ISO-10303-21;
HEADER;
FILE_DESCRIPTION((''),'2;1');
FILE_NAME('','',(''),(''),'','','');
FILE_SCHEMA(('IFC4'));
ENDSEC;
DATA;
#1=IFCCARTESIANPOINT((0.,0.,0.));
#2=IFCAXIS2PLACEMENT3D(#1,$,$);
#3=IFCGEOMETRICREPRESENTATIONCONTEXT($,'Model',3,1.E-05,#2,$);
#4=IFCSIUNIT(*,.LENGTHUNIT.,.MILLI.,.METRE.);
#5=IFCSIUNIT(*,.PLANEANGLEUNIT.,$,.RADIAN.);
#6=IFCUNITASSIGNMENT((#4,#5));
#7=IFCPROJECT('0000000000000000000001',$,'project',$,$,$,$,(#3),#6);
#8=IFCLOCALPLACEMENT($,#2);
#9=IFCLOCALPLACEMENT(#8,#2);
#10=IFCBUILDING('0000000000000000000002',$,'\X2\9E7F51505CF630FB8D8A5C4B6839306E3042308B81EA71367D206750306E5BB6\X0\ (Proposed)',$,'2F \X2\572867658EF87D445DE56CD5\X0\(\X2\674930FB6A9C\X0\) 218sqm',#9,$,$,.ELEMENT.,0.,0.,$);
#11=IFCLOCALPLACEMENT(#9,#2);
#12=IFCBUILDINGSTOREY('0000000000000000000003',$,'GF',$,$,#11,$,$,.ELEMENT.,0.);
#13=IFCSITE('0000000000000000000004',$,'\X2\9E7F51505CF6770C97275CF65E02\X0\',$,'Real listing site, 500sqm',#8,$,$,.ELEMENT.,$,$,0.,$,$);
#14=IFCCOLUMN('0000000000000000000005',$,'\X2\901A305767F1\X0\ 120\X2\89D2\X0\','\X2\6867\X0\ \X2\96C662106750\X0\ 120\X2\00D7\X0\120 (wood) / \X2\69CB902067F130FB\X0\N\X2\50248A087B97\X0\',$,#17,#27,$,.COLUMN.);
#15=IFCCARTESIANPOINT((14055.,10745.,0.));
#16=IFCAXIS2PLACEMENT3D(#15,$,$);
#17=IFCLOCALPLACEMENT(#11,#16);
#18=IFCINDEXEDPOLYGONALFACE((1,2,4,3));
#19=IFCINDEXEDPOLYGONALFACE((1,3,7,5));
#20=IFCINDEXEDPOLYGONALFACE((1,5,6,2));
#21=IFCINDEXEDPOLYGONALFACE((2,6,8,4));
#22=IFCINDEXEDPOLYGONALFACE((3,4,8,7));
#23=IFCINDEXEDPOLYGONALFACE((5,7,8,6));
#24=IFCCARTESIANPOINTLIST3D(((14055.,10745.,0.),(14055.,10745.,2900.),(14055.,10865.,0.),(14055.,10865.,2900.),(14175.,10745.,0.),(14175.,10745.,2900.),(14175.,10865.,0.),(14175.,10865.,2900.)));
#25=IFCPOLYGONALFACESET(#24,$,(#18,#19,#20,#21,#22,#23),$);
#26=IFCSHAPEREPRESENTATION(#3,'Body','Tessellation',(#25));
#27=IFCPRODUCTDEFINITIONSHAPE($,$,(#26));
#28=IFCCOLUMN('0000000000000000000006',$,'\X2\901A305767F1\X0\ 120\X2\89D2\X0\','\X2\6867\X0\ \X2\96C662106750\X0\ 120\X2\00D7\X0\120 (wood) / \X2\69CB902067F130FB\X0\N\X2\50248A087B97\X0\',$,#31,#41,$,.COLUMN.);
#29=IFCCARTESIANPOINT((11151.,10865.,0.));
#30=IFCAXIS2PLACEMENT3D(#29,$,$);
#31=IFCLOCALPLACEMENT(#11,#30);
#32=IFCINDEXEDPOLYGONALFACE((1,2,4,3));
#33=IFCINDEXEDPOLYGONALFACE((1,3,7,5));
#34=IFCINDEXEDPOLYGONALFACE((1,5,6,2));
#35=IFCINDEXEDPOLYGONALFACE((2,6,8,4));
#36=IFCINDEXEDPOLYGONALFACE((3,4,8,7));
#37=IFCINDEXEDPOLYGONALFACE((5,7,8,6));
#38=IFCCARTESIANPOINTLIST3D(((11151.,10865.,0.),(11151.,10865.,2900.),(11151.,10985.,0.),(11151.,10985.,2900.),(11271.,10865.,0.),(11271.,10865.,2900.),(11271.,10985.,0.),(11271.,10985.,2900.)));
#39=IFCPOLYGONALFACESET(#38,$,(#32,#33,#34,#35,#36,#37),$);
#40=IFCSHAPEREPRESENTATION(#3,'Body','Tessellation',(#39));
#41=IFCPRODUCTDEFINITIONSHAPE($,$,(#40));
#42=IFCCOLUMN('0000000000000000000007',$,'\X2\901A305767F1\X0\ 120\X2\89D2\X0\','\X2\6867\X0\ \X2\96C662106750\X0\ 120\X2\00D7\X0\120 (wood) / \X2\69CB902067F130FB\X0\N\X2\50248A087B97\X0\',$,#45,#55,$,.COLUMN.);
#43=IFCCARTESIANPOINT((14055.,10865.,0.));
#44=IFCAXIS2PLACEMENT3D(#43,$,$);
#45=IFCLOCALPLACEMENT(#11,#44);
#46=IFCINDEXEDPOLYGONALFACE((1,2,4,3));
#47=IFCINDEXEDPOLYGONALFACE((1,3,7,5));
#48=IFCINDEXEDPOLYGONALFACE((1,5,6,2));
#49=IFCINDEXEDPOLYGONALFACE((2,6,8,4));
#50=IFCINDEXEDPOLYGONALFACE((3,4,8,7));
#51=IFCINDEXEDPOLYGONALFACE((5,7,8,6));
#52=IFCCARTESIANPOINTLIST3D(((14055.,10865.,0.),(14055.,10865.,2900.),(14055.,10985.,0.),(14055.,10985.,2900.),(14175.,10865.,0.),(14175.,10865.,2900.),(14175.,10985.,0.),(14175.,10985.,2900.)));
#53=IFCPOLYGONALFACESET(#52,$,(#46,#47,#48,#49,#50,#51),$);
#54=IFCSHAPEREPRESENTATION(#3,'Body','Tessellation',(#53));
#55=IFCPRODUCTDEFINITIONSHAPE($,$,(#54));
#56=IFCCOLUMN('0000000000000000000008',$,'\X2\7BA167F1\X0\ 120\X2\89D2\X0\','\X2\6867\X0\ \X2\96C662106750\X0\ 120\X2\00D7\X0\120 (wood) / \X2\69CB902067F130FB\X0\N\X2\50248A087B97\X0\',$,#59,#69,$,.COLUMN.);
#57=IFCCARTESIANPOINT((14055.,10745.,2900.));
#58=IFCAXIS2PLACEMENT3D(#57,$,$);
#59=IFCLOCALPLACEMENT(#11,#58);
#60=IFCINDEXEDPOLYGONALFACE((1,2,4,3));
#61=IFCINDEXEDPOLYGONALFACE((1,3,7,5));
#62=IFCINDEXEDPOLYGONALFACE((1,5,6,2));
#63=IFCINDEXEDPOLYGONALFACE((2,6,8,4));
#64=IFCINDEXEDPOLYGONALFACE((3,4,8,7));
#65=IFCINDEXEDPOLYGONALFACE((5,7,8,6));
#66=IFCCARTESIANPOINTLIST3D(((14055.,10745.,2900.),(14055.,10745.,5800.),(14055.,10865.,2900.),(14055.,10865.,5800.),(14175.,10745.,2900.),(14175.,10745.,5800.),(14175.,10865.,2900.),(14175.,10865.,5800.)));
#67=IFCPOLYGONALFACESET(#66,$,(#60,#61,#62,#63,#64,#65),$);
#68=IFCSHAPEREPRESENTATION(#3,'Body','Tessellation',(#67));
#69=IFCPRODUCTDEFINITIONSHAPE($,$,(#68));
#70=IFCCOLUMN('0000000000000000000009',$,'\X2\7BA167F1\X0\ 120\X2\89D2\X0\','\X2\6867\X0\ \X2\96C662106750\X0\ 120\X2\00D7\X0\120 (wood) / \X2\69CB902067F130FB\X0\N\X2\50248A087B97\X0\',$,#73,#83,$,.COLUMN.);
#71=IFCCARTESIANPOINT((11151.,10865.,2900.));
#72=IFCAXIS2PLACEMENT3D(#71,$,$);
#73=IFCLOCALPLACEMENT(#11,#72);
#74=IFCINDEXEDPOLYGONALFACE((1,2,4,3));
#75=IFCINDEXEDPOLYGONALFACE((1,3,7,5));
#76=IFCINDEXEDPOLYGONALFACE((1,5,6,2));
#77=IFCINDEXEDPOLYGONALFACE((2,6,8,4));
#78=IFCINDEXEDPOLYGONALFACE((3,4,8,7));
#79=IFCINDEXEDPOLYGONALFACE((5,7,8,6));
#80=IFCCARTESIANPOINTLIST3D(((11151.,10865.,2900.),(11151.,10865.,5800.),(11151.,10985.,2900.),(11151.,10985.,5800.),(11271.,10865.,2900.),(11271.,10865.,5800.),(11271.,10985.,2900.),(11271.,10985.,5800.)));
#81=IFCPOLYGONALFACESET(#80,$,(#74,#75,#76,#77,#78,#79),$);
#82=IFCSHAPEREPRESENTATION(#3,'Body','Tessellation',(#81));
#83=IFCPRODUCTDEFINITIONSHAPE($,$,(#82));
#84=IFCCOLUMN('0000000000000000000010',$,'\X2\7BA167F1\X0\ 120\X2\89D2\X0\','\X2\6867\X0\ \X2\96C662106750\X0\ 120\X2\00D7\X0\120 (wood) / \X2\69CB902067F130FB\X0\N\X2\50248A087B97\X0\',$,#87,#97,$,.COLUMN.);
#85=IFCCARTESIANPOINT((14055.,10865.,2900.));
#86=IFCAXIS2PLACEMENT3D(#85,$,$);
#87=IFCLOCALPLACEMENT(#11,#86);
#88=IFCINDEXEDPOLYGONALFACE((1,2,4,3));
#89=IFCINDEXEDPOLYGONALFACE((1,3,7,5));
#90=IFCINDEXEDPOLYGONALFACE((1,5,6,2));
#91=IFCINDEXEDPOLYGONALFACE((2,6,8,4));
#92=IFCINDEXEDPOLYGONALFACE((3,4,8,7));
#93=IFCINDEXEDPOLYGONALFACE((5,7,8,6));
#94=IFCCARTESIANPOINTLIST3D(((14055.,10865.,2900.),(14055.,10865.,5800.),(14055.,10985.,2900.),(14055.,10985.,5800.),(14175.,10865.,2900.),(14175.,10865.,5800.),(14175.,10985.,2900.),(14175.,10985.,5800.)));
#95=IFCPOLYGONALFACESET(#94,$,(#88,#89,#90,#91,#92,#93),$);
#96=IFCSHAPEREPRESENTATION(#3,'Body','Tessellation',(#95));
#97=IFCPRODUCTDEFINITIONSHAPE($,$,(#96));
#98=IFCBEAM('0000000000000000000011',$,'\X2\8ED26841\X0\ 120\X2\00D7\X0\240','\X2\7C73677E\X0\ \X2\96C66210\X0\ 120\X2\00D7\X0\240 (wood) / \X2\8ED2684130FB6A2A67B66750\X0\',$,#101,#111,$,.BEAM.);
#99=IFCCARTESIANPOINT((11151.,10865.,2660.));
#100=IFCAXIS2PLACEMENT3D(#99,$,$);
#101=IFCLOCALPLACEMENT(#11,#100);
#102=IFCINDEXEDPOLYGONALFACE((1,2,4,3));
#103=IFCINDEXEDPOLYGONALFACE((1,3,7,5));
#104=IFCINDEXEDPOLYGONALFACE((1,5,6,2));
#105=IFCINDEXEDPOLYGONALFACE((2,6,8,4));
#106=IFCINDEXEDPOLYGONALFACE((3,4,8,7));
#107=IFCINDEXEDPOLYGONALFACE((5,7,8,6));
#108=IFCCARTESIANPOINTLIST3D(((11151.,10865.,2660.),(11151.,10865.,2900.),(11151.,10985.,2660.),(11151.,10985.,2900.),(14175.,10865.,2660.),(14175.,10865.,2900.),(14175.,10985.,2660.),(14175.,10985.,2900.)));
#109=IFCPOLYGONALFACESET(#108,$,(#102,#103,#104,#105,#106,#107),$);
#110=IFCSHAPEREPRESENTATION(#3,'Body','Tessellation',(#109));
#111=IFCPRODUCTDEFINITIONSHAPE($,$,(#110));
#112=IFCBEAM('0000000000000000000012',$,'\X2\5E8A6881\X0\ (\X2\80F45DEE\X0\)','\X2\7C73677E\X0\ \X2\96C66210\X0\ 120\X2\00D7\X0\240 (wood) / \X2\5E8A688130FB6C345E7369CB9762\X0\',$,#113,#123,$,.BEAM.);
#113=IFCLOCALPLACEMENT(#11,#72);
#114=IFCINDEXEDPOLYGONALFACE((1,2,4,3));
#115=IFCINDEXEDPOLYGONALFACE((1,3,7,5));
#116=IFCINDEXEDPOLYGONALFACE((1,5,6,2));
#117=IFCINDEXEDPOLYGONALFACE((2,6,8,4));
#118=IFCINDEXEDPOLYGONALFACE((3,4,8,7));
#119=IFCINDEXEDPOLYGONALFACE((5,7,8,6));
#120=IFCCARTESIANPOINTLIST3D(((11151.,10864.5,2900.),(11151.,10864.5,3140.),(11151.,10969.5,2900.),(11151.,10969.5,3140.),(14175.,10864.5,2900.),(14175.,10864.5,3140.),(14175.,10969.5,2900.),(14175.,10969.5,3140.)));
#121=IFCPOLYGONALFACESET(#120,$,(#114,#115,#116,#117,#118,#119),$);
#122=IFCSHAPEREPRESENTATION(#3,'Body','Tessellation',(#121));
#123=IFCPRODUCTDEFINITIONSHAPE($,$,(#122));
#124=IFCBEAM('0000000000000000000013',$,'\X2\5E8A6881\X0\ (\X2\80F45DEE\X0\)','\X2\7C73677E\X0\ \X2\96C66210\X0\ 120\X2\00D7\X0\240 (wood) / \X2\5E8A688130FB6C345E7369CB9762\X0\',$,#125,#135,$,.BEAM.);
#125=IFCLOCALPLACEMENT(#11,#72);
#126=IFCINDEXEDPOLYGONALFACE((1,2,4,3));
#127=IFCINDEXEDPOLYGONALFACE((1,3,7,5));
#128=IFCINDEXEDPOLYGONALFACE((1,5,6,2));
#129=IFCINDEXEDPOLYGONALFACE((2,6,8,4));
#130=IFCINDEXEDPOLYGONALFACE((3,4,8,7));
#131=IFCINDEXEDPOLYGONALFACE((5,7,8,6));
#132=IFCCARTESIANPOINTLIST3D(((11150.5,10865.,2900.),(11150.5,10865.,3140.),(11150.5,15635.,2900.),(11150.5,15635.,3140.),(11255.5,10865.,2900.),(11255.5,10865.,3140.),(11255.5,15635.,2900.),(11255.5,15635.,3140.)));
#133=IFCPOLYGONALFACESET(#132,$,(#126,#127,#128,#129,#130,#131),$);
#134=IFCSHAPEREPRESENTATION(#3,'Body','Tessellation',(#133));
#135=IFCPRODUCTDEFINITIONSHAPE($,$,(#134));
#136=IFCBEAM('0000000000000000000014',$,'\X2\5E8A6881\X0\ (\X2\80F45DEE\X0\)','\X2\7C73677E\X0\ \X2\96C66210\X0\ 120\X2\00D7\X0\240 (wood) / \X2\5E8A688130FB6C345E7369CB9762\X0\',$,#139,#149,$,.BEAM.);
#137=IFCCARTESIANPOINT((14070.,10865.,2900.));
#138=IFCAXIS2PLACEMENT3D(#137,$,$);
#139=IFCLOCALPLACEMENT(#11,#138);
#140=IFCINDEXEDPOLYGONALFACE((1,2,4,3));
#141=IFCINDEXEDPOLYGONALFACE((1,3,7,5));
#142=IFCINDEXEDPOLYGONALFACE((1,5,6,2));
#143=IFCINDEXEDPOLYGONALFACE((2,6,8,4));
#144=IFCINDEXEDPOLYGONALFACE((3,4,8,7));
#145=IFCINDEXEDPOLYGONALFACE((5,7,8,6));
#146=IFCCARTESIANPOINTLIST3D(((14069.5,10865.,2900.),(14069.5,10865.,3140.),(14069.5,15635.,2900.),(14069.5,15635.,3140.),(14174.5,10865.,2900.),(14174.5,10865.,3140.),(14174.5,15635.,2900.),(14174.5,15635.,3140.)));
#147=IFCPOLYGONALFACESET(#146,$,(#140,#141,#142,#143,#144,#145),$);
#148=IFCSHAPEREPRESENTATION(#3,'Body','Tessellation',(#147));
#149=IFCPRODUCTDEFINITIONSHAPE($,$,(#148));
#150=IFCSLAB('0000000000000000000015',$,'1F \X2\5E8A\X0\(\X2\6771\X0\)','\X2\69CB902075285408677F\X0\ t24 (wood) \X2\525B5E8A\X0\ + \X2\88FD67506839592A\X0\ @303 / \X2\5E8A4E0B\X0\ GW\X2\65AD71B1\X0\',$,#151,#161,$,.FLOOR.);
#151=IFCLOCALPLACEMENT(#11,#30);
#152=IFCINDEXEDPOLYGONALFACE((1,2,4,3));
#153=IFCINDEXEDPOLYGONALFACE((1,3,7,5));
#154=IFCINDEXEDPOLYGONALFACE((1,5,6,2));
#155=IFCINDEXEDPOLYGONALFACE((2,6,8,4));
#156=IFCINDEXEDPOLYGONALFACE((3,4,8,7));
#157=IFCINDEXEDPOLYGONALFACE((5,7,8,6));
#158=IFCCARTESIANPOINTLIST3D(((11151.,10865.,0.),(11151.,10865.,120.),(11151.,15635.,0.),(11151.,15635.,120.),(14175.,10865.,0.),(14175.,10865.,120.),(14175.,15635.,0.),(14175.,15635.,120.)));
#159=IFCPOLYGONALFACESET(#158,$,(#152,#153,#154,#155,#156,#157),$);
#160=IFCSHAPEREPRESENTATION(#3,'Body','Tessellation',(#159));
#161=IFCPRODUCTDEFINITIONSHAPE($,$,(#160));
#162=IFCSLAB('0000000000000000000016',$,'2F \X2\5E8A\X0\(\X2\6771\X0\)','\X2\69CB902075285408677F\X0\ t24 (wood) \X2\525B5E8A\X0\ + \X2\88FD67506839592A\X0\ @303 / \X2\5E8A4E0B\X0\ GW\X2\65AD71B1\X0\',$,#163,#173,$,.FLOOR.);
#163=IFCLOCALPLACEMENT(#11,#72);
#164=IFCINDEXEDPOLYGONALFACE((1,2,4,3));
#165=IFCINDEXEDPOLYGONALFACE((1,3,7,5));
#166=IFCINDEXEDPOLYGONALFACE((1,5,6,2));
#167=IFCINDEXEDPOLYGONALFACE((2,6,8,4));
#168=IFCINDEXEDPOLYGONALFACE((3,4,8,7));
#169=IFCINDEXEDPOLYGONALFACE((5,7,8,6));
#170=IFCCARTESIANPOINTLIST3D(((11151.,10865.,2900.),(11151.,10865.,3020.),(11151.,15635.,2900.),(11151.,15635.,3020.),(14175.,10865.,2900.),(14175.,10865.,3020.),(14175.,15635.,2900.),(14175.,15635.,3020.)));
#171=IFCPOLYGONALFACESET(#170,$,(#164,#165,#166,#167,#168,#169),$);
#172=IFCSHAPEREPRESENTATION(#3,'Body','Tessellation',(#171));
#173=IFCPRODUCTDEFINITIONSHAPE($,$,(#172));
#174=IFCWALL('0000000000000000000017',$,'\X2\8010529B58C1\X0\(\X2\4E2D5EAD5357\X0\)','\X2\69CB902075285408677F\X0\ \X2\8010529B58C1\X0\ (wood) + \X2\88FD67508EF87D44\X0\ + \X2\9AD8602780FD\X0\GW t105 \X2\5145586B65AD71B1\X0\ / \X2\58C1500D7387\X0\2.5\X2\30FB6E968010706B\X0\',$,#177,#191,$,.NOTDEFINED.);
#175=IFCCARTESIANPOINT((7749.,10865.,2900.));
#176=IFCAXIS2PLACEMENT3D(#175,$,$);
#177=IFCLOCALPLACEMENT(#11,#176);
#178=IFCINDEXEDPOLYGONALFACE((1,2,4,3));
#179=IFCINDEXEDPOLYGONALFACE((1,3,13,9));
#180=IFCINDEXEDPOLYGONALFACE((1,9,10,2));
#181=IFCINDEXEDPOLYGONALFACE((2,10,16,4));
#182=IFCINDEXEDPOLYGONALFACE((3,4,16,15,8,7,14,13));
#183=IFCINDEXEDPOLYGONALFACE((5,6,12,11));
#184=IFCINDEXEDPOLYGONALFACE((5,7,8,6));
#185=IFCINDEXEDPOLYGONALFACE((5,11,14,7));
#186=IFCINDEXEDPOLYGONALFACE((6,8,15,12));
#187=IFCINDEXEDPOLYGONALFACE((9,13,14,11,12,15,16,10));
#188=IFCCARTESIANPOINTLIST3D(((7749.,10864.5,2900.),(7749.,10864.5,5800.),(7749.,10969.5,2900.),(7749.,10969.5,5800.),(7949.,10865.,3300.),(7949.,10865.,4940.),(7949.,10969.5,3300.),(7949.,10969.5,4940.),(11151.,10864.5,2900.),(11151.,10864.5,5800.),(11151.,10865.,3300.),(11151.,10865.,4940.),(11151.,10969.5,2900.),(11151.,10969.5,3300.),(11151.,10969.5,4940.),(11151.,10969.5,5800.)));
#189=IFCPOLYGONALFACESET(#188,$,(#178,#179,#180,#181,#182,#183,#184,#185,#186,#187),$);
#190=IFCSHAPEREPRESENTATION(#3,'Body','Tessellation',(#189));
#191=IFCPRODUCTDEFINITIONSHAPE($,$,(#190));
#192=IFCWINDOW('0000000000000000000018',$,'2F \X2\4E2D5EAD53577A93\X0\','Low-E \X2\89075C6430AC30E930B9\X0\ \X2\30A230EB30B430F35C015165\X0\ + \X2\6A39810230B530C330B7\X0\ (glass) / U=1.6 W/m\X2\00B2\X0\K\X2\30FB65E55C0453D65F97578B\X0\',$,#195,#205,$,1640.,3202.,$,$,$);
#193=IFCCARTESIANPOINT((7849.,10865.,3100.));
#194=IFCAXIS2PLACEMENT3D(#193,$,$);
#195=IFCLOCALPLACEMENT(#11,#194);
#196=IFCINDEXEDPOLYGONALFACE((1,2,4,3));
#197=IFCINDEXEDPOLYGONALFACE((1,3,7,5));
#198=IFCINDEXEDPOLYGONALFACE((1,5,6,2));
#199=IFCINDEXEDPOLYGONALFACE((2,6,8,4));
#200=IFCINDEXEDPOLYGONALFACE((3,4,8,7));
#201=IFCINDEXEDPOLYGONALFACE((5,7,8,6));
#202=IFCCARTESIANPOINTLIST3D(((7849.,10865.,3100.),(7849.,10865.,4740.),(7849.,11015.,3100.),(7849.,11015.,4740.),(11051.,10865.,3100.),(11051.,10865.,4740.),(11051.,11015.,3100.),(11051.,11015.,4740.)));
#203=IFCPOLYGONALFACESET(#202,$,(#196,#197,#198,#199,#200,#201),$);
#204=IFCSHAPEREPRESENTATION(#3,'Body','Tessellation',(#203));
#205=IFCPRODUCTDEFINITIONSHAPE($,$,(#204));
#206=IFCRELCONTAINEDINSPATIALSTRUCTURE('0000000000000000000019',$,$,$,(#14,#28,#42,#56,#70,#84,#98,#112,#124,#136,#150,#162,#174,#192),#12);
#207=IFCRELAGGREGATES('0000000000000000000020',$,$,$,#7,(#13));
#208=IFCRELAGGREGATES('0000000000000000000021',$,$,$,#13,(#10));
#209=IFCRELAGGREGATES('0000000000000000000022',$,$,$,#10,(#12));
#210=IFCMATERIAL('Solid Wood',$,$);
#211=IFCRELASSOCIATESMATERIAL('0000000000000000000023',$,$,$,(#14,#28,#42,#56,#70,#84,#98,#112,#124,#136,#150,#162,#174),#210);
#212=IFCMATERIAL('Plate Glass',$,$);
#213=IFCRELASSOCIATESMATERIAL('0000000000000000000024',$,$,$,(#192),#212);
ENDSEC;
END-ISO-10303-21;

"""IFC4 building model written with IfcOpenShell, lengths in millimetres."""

from ifc_helpers import new_model, si_unit, frame, frame_2d, origin, place, context, project, spatial, rectangle, extrude, material, element, fill, save


model = new_model("IFC4")

# Units and contexts
model_context = context("Model", 3, precision=1e-05, world=origin())
ifc_project = project(units=[si_unit("LENGTHUNIT", "METRE", prefix="MILLI"), si_unit("PLANEANGLEUNIT", "RADIAN")], contexts=[model_context])

# Site, building, storey
site_placement = place(None, origin())
site = spatial("IfcSite", under=ifc_project, at=site_placement, Name="鹿児島県霧島市", ObjectType="Real listing site, 500sqm", CompositionType="ELEMENT", RefElevation=0.0)
building_placement = place(site_placement, origin())
building = spatial("IfcBuilding", under=site, at=building_placement, Name="鹿児島・越屋根のある自然素材の家 (Proposed)", ObjectType="2F 在来軸組工法(杉・檜) 218sqm", CompositionType="ELEMENT", ElevationOfRefHeight=0.0, ElevationOfTerrain=0.0)
storey_placement = place(building_placement, origin())
storey = spatial("IfcBuildingStorey", under=building, at=storey_placement, Name="GF", CompositionType="ELEMENT", Elevation=0.0)

# Columns
ifc_material_1 = material(Name="Solid Wood")
column_1_placement = place(storey_placement, frame((14055.0, 10745.0, 0.0)))
element("IfcColumn", 1, at=column_1_placement, inside=storey, material=ifc_material_1, Name="通し柱 120角", Description="桧 集成材 120×120 (wood) / 構造柱・N値計算", PredefinedType="COLUMN", context=model_context, shape_type="SweptSolid", body=[
    extrude(rectangle(XDim=120.0, YDim=120.0, at=frame_2d((60.0, 60.0))), frame((14055.0, 10745.0, 0.0)), (0.0, 0.0, 1.0), 2900.0),
])
column_2_placement = place(storey_placement, frame((11151.0, 10865.0, 0.0)))
element("IfcColumn", 2, at=column_2_placement, inside=storey, material=ifc_material_1, Name="通し柱 120角", Description="桧 集成材 120×120 (wood) / 構造柱・N値計算", PredefinedType="COLUMN", context=model_context, shape_type="SweptSolid", body=[
    extrude(rectangle(XDim=120.0, YDim=120.0, at=frame_2d((60.0, 60.0))), frame((11151.0, 10865.0, 0.0)), (0.0, 0.0, 1.0), 2900.0),
])
column_3_placement = place(storey_placement, frame((14055.0, 10865.0, 0.0)))
element("IfcColumn", 3, at=column_3_placement, inside=storey, material=ifc_material_1, Name="通し柱 120角", Description="桧 集成材 120×120 (wood) / 構造柱・N値計算", PredefinedType="COLUMN", context=model_context, shape_type="SweptSolid", body=[
    extrude(rectangle(XDim=120.0, YDim=120.0, at=frame_2d((60.0, 60.0))), frame((14055.0, 10865.0, 0.0)), (0.0, 0.0, 1.0), 2900.0),
])
column_4_placement = place(storey_placement, frame((14055.0, 10745.0, 2900.0)))
element("IfcColumn", 4, at=column_4_placement, inside=storey, material=ifc_material_1, Name="管柱 120角", Description="桧 集成材 120×120 (wood) / 構造柱・N値計算", PredefinedType="COLUMN", context=model_context, shape_type="SweptSolid", body=[
    extrude(rectangle(XDim=120.0, YDim=120.0, at=frame_2d((60.0, 60.0))), frame((14055.0, 10745.0, 2900.0)), (0.0, 0.0, 1.0), 2900.0),
])
column_5_placement = place(storey_placement, frame((11151.0, 10865.0, 2900.0)))
element("IfcColumn", 5, at=column_5_placement, inside=storey, material=ifc_material_1, Name="管柱 120角", Description="桧 集成材 120×120 (wood) / 構造柱・N値計算", PredefinedType="COLUMN", context=model_context, shape_type="SweptSolid", body=[
    extrude(rectangle(XDim=120.0, YDim=120.0, at=frame_2d((60.0, 60.0))), frame((11151.0, 10865.0, 2900.0)), (0.0, 0.0, 1.0), 2900.0),
])
column_6_placement = place(storey_placement, frame((14055.0, 10865.0, 2900.0)))
element("IfcColumn", 6, at=column_6_placement, inside=storey, material=ifc_material_1, Name="管柱 120角", Description="桧 集成材 120×120 (wood) / 構造柱・N値計算", PredefinedType="COLUMN", context=model_context, shape_type="SweptSolid", body=[
    extrude(rectangle(XDim=120.0, YDim=120.0, at=frame_2d((60.0, 60.0))), frame((14055.0, 10865.0, 2900.0)), (0.0, 0.0, 1.0), 2900.0),
])

# Beams
beam_1_placement = place(storey_placement, frame((11151.0, 10865.0, 2660.0)))
element("IfcBeam", 7, at=beam_1_placement, inside=storey, material=ifc_material_1, Name="軒桁 120×240", Description="米松 集成 120×240 (wood) / 軒桁・横架材", PredefinedType="BEAM", context=model_context, shape_type="SweptSolid", body=[
    extrude(rectangle(XDim=3024.0, YDim=120.0, at=frame_2d((1512.0, 60.0))), frame((11151.0, 10865.0, 2660.0)), (0.0, 0.0, 1.0), 240.0),
])
beam_2_placement = place(storey_placement, frame((11151.0, 10865.0, 2900.0)))
element("IfcBeam", 8, at=beam_2_placement, inside=storey, material=ifc_material_1, Name="床梁 (胴差)", Description="米松 集成 120×240 (wood) / 床梁・水平構面", PredefinedType="BEAM", context=model_context, shape_type="SweptSolid", body=[
    extrude(rectangle(XDim=3024.0, YDim=105.0, at=frame_2d((1512.0, 52.0))), frame((11151.0, 10865.0, 2900.0)), (0.0, 0.0, 1.0), 240.0),
])
beam_3_placement = place(storey_placement, frame((11151.0, 10865.0, 2900.0)))
element("IfcBeam", 9, at=beam_3_placement, inside=storey, material=ifc_material_1, Name="床梁 (胴差)", Description="米松 集成 120×240 (wood) / 床梁・水平構面", PredefinedType="BEAM", context=model_context, shape_type="SweptSolid", body=[
    extrude(rectangle(XDim=105.0, YDim=4770.0, at=frame_2d((52.0, 2385.0))), frame((11151.0, 10865.0, 2900.0)), (0.0, 0.0, 1.0), 240.0),
])
beam_4_placement = place(storey_placement, frame((14070.0, 10865.0, 2900.0)))
element("IfcBeam", 10, at=beam_4_placement, inside=storey, material=ifc_material_1, Name="床梁 (胴差)", Description="米松 集成 120×240 (wood) / 床梁・水平構面", PredefinedType="BEAM", context=model_context, shape_type="SweptSolid", body=[
    extrude(rectangle(XDim=105.0, YDim=4770.0, at=frame_2d((52.0, 2385.0))), frame((14070.0, 10865.0, 2900.0)), (0.0, 0.0, 1.0), 240.0),
])

# Slabs
slab_1_placement = place(storey_placement, frame((11151.0, 10865.0, 0.0)))
element("IfcSlab", 11, at=slab_1_placement, inside=storey, material=ifc_material_1, Name="1F 床(東)", Description="構造用合板 t24 (wood) 剛床 + 製材根太 @303 / 床下 GW断熱", PredefinedType="FLOOR", context=model_context, shape_type="SweptSolid", body=[
    extrude(rectangle(XDim=3024.0, YDim=4770.0, at=frame_2d((1512.0, 2385.0))), frame((11151.0, 10865.0, 0.0)), (0.0, 0.0, 1.0), 120.0),
])
slab_2_placement = place(storey_placement, frame((11151.0, 10865.0, 2900.0)))
element("IfcSlab", 12, at=slab_2_placement, inside=storey, material=ifc_material_1, Name="2F 床(東)", Description="構造用合板 t24 (wood) 剛床 + 製材根太 @303 / 床下 GW断熱", PredefinedType="FLOOR", context=model_context, shape_type="SweptSolid", body=[
    extrude(rectangle(XDim=3024.0, YDim=4770.0, at=frame_2d((1512.0, 2385.0))), frame((11151.0, 10865.0, 2900.0)), (0.0, 0.0, 1.0), 120.0),
])

# Wall, opening, window
wall_1_placement = place(storey_placement, frame((7749.0, 10865.0, 2900.0)))
wall_1 = element("IfcWall", 13, at=wall_1_placement, inside=storey, material=ifc_material_1, Name="耐力壁(中庭南)", Description="構造用合板 耐力壁 (wood) + 製材軸組 + 高性能GW t105 充填断熱 / 壁倍率2.5・準耐火", PredefinedType="NOTDEFINED", context=model_context, shape_type="SweptSolid", body=[
    extrude(rectangle(XDim=3402.0, YDim=105.0, at=frame_2d((1701.0, 52.0))), frame((7749.0, 10865.0, 2900.0)), (0.0, 0.0, 1.0), 2900.0),
])
opening_placement = place(storey_placement, frame((7849.0, 10865.0, 3100.0)))
opening = element("IfcOpeningElement", 14, at=opening_placement, cuts=wall_1, PredefinedType="NOTDEFINED", context=model_context, shape_type="SweptSolid", body=[
    extrude(rectangle(XDim=3202.0, YDim=150.0, at=frame_2d((1601.0, 75.0))), frame((7849.0, 10865.0, 3100.0)), (0.0, 0.0, 1.0), 1640.0),
])
ifc_material_2 = material(Name="Plate Glass")
window_placement = place(storey_placement, frame((7849.0, 10865.0, 3100.0)))
window = element("IfcWindow", 15, at=window_placement, inside=storey, material=ifc_material_2, Name="2F 中庭南窓", Description="Low-E 複層ガラス アルゴン封入 + 樹脂サッシ (glass) / U=1.6 W/m²K・日射取得型", OverallHeight=1640.0, OverallWidth=3202.0, context=model_context, shape_type="SweptSolid", body=[
    extrude(rectangle(XDim=3202.0, YDim=150.0, at=frame_2d((1601.0, 75.0))), frame((7849.0, 10865.0, 3100.0)), (0.0, 0.0, 1.0), 1640.0),
])
fill(opening, window)

save(model, "model.ifc")
